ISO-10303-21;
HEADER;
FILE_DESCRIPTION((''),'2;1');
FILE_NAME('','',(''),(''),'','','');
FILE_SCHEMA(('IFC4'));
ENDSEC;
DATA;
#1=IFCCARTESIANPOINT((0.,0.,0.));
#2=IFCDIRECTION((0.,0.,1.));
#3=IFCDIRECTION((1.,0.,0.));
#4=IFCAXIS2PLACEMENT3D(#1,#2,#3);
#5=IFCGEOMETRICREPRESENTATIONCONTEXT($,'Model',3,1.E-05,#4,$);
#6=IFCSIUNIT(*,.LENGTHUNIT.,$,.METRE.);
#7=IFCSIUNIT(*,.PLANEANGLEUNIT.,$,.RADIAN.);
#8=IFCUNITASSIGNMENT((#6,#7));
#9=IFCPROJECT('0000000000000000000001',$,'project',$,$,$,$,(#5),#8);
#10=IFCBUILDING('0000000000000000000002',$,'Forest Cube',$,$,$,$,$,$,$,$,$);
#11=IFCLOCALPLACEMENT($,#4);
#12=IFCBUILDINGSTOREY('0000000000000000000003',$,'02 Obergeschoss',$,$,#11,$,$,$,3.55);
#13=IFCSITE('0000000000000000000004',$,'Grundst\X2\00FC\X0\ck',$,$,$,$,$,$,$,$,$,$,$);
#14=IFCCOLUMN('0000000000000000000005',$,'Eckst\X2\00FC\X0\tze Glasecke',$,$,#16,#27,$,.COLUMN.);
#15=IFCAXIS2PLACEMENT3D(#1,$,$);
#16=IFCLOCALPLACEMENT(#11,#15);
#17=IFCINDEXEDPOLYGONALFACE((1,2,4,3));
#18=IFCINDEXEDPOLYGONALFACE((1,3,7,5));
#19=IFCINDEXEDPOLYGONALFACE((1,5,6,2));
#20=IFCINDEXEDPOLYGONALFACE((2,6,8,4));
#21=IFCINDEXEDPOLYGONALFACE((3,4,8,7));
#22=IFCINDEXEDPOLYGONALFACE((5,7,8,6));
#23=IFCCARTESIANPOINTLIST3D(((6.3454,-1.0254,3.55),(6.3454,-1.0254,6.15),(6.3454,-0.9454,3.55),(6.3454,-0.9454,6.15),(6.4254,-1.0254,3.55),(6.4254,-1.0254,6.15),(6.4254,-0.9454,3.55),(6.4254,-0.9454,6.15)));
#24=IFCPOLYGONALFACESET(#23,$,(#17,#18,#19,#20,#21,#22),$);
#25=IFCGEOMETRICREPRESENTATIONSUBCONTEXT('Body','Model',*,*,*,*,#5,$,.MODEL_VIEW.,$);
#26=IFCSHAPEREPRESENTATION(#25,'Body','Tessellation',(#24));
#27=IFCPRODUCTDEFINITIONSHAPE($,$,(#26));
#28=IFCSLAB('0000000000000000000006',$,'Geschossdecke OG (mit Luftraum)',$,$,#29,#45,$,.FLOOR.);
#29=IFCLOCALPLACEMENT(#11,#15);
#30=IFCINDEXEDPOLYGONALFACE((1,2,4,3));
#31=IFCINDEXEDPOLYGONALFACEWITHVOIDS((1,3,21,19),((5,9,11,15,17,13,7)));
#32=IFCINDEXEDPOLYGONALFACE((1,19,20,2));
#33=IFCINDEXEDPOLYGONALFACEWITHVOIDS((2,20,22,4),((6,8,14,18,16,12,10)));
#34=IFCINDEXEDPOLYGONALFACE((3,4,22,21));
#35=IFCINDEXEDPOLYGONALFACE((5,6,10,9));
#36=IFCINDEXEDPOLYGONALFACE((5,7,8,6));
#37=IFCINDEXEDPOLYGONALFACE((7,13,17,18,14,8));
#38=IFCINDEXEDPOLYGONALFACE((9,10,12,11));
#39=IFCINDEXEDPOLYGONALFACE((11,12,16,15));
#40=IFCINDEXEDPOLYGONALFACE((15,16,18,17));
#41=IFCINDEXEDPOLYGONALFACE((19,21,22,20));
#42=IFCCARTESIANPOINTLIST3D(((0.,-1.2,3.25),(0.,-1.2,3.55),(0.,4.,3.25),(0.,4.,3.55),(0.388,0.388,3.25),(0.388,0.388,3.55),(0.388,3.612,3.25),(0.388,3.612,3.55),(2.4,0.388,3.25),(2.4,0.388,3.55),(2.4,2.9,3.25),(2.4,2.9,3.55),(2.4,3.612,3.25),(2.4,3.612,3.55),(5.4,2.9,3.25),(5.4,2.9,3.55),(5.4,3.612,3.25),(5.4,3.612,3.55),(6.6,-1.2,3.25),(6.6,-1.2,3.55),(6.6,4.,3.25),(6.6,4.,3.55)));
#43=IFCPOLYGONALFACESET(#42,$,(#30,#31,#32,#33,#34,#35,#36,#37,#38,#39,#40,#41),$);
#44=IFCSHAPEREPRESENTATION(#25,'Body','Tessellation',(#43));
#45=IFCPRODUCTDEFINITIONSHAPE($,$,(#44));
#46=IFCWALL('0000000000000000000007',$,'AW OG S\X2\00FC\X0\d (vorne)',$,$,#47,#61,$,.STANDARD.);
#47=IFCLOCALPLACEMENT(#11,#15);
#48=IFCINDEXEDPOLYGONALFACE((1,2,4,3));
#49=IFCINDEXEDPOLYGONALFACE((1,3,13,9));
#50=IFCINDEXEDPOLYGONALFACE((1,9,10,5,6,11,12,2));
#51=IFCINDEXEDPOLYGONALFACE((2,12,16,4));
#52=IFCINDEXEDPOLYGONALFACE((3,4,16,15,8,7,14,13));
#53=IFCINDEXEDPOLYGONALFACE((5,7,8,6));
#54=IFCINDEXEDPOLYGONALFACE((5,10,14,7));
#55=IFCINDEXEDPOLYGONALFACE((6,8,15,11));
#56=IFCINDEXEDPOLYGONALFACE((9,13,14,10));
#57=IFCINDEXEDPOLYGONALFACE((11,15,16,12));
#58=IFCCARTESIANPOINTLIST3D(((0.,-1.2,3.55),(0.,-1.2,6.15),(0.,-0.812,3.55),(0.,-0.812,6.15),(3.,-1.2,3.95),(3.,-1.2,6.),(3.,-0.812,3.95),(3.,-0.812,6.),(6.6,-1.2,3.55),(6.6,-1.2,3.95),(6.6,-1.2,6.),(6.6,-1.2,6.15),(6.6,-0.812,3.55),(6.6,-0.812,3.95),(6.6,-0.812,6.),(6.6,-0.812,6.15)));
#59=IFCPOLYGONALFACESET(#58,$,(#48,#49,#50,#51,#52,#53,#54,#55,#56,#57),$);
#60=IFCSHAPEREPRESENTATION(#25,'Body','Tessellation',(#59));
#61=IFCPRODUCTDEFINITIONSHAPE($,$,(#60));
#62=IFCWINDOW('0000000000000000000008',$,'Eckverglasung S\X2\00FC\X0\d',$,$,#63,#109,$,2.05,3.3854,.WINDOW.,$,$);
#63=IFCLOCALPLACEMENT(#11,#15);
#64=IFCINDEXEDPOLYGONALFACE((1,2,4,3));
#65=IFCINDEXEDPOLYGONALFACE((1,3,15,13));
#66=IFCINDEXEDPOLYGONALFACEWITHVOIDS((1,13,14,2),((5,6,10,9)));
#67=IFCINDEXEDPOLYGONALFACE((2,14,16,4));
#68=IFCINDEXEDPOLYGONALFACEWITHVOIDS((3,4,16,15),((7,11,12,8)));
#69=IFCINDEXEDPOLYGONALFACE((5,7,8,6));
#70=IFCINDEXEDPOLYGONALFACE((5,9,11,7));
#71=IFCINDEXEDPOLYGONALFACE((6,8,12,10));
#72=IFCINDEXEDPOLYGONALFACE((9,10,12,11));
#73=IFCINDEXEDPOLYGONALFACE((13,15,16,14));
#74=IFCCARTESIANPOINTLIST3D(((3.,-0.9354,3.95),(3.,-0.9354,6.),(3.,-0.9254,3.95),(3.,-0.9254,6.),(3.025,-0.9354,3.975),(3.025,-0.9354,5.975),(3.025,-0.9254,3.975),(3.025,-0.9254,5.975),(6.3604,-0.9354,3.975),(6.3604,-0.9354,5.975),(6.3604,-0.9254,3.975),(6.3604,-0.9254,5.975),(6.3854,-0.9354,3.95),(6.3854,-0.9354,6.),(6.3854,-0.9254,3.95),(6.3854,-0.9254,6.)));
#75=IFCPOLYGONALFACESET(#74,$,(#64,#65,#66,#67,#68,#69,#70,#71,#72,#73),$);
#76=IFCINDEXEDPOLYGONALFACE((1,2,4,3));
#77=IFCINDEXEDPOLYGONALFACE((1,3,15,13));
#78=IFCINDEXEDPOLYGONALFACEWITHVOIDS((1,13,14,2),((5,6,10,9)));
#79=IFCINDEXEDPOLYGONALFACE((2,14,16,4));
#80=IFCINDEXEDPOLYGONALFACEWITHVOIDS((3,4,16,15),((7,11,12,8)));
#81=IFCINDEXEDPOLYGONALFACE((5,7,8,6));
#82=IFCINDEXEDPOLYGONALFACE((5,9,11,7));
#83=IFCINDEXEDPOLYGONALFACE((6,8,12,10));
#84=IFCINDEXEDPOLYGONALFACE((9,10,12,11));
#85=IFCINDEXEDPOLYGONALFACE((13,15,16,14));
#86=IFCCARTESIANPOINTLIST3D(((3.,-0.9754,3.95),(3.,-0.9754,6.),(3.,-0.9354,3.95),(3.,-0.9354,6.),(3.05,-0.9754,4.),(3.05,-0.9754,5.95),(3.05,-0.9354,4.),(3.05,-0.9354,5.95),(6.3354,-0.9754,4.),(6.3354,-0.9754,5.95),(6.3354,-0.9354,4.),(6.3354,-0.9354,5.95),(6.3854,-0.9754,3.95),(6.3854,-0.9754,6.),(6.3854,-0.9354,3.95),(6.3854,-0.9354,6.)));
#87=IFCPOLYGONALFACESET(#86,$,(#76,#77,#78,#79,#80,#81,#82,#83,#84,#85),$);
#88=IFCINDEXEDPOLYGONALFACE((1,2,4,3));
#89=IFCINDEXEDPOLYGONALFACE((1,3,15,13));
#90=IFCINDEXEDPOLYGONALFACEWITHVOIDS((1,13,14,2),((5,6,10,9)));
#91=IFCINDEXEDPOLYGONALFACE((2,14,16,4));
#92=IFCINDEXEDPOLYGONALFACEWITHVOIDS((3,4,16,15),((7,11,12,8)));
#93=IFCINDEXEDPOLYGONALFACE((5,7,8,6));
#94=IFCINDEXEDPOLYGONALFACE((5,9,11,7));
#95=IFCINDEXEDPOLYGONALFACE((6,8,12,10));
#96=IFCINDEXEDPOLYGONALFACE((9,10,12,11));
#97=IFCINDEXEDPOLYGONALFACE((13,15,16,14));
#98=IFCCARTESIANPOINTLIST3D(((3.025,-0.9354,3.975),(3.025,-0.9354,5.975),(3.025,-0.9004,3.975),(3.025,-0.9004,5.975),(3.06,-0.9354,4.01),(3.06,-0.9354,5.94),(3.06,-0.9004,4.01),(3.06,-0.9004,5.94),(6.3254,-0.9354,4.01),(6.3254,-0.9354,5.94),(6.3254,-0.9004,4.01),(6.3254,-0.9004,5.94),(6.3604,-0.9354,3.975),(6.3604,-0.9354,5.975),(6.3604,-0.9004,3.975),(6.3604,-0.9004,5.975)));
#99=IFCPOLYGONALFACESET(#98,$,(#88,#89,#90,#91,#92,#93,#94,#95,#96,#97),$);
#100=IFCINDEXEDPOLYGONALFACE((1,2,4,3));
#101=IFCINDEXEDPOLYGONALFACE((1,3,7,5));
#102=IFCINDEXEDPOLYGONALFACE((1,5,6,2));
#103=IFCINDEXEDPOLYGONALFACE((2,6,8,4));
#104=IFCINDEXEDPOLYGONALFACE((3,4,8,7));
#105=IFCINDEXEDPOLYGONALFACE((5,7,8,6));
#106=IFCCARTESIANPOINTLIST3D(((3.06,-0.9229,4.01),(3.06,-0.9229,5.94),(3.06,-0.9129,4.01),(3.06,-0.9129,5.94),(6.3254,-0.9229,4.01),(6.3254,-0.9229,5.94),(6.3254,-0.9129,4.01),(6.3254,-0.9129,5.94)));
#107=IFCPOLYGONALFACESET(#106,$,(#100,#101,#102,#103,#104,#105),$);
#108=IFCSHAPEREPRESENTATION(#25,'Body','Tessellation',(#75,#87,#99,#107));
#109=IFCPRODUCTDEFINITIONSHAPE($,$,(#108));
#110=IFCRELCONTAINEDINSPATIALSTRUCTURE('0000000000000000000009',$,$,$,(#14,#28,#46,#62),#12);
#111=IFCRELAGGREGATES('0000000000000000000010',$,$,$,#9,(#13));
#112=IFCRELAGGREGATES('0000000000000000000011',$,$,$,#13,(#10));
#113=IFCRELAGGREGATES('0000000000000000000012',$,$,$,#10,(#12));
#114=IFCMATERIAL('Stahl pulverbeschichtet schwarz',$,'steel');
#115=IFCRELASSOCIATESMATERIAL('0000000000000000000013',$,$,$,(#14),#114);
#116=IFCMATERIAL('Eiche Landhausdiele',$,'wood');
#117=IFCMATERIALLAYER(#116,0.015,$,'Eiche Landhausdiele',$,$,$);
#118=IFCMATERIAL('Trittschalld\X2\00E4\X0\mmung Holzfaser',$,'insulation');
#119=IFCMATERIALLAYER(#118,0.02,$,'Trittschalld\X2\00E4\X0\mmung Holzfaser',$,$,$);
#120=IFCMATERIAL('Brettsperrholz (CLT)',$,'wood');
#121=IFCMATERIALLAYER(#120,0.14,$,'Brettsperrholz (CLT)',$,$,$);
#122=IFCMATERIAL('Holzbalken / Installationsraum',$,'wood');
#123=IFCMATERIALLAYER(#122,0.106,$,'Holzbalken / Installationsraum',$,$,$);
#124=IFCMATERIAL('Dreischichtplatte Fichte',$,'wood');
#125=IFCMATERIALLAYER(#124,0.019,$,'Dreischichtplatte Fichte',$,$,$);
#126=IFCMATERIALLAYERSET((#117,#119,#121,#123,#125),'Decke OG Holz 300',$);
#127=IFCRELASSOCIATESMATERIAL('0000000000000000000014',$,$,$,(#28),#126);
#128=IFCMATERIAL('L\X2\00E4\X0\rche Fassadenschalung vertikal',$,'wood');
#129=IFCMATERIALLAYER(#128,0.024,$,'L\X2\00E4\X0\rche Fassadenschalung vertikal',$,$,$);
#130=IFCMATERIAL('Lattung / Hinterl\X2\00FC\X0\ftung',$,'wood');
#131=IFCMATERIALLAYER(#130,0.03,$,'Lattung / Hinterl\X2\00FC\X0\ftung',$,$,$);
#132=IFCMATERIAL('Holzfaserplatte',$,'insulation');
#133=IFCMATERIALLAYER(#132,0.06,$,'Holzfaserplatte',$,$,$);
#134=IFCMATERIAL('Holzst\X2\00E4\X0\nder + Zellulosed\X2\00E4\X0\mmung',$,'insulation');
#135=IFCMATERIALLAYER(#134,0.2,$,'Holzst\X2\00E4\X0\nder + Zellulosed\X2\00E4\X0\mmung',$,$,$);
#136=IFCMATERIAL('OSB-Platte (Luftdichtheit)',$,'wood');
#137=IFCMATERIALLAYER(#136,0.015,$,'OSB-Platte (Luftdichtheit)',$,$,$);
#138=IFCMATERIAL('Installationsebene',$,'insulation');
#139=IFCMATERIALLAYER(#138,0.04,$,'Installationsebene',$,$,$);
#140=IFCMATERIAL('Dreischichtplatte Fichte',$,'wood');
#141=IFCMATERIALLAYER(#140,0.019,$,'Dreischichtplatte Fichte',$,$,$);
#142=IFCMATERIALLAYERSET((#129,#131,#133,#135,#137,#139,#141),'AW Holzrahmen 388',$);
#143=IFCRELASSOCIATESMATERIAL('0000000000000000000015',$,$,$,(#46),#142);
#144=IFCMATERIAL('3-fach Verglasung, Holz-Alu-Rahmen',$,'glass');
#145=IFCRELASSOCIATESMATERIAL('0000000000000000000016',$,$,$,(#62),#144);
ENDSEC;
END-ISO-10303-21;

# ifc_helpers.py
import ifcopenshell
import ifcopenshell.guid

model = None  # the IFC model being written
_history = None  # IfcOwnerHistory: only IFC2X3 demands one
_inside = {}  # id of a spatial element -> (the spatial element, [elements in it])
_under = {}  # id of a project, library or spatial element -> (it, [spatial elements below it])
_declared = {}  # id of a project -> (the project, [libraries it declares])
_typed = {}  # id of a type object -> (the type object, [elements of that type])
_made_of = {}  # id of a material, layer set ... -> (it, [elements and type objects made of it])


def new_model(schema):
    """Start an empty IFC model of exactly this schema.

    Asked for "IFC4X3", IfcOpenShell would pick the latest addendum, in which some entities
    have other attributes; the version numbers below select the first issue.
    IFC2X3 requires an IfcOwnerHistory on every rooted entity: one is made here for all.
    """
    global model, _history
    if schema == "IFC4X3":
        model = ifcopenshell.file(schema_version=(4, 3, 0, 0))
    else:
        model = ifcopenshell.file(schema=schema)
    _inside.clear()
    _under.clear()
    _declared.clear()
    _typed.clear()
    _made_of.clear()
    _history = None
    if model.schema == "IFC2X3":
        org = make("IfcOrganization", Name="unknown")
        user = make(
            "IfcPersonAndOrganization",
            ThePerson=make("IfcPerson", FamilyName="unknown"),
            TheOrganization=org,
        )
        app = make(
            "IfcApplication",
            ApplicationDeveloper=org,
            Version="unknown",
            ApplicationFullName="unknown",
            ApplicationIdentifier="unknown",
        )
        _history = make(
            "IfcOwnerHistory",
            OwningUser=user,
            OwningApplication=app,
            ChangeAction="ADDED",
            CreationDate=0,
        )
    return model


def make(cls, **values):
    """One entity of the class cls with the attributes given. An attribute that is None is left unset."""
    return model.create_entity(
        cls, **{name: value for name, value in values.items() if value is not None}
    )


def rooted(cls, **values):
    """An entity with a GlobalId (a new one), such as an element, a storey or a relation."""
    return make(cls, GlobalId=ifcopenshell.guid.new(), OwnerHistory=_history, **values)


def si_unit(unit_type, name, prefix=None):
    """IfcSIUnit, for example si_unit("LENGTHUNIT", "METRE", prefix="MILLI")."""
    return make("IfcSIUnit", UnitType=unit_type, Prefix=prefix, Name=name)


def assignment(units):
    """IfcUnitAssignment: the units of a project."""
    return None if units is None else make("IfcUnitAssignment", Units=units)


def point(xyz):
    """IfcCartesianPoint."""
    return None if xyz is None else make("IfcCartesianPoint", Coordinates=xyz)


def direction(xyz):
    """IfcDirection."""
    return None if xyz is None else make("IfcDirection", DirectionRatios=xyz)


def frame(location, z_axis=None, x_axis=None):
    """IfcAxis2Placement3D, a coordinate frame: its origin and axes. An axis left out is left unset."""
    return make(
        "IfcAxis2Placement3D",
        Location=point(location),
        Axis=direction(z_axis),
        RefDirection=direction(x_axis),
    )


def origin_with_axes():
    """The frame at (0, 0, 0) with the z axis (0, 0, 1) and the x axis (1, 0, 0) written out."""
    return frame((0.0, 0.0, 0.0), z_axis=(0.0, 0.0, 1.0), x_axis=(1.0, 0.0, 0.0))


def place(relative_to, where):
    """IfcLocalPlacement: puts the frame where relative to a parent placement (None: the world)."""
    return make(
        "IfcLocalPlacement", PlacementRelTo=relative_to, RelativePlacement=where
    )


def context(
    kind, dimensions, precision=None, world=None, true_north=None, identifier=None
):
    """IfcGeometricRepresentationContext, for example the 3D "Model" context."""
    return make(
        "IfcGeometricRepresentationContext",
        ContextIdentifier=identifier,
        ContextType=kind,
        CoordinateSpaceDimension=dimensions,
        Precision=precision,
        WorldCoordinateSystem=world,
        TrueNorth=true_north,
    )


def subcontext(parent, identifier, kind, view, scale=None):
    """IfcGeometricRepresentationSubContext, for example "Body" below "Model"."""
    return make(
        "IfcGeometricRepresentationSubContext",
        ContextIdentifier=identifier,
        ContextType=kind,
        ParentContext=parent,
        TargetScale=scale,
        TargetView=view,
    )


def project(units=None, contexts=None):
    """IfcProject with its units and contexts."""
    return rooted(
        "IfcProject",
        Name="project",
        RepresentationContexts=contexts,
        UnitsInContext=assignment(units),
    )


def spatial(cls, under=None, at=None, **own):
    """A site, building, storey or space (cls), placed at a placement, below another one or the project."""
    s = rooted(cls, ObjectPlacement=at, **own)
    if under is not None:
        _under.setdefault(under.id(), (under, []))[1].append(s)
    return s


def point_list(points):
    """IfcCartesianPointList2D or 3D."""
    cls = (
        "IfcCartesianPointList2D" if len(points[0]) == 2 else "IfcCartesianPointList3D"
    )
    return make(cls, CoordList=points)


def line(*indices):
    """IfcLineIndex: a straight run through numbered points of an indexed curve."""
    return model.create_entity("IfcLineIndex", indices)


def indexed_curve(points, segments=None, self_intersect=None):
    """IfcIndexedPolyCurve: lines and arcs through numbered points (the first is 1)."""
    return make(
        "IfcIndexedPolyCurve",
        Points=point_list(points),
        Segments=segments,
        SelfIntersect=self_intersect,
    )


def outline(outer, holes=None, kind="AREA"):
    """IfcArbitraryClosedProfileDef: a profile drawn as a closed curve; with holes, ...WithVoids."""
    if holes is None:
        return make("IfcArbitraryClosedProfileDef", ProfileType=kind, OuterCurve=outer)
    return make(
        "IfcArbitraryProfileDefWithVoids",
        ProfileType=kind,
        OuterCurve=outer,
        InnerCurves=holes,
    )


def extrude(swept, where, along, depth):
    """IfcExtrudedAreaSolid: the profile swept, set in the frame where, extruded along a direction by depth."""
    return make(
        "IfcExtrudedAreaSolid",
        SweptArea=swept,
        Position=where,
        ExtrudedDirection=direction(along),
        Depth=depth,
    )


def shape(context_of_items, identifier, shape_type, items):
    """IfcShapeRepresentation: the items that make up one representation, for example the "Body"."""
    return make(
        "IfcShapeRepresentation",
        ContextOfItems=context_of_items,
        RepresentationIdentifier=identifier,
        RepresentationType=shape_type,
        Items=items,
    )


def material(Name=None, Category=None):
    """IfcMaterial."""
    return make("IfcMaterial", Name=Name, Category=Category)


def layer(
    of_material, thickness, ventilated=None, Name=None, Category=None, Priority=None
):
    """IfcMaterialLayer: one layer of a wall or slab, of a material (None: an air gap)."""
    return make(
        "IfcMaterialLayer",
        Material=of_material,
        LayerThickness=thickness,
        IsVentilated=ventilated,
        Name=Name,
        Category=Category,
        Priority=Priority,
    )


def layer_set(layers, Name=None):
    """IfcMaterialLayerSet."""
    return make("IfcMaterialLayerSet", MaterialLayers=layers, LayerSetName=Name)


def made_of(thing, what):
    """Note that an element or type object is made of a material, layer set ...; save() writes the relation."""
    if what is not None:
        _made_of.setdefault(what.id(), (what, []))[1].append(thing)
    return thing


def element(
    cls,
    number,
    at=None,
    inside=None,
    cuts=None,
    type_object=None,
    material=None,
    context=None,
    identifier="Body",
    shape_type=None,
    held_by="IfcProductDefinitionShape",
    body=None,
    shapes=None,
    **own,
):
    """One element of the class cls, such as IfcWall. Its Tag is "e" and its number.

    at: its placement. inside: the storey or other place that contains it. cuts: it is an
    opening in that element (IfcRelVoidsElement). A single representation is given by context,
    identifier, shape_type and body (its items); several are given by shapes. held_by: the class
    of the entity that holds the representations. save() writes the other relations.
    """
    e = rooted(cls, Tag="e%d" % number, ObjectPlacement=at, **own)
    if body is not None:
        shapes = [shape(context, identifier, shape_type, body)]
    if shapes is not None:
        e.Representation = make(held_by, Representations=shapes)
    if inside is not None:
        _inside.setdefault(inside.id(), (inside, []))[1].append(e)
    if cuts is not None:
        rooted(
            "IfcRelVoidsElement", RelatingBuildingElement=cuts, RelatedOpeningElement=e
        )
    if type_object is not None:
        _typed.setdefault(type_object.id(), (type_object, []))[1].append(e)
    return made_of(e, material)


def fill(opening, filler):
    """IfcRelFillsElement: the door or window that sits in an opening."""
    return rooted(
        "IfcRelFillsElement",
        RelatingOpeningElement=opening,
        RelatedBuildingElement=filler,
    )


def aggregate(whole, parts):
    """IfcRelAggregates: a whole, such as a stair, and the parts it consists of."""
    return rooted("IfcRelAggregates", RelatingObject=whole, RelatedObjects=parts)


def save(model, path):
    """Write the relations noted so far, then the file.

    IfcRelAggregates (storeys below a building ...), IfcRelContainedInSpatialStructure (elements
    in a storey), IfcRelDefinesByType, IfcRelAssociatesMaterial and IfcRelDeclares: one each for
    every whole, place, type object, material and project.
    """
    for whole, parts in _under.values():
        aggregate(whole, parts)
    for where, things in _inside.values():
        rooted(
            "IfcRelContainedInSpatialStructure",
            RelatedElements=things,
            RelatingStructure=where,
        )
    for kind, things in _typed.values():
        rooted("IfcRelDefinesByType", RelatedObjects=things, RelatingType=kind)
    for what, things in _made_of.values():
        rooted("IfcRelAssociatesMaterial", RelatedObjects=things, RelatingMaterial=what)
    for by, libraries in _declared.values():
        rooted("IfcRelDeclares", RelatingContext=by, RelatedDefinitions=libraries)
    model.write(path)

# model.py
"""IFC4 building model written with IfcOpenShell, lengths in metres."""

from ifc_helpers import new_model, si_unit, frame, origin_with_axes, place, context, subcontext, project, spatial, line, indexed_curve, outline, extrude, material, layer, layer_set, element, fill, save


model = new_model("IFC4")

# Units and contexts
model_context = context("Model", 3, precision=1e-05, world=origin_with_axes())
body_context = subcontext(model_context, "Body", "Model", "MODEL_VIEW")
ifc_project = project(units=[si_unit("LENGTHUNIT", "METRE"), si_unit("PLANEANGLEUNIT", "RADIAN")], contexts=[model_context])

# Site, building, storey
site = spatial("IfcSite", under=ifc_project, Name="Grundstück")
building = spatial("IfcBuilding", under=site, Name="Forest Cube")
storey_placement = place(None, origin_with_axes())
storey = spatial("IfcBuildingStorey", under=building, at=storey_placement, Name="02 Obergeschoss", Elevation=3.55)

# Column
ifc_material_1 = material(Name="Stahl pulverbeschichtet schwarz", Category="steel")
column_placement = place(storey_placement, frame((6.3854, -0.9854, 3.55), z_axis=(0.0, 0.0, 1.0), x_axis=(1.0, 0.0, 0.0)))
element("IfcColumn", 1, at=column_placement, inside=storey, material=ifc_material_1, Name="Eckstütze Glasecke", PredefinedType="COLUMN", context=body_context, shape_type="SweptSolid", body=[
    extrude(outline(indexed_curve([(-0.04, -0.04), (0.04, -0.04), (0.04, 0.04), (-0.04, 0.04)])), None, (0.0, 0.0, 1.0), 2.6),
])

# Slab, openings
ifc_material_2 = material(Name="Eiche Landhausdiele", Category="wood")
ifc_layer_1 = layer(ifc_material_2, 0.015, Name="Eiche Landhausdiele")
ifc_material_3 = material(Name="Trittschalldämmung Holzfaser", Category="insulation")
ifc_layer_2 = layer(ifc_material_3, 0.02, Name="Trittschalldämmung Holzfaser")
ifc_material_4 = material(Name="Brettsperrholz (CLT)", Category="wood")
ifc_layer_3 = layer(ifc_material_4, 0.14, Name="Brettsperrholz (CLT)")
ifc_material_5 = material(Name="Holzbalken / Installationsraum", Category="wood")
ifc_layer_4 = layer(ifc_material_5, 0.106, Name="Holzbalken / Installationsraum")
ifc_material_6 = material(Name="Dreischichtplatte Fichte", Category="wood")
ifc_layer_5 = layer(ifc_material_6, 0.019, Name="Dreischichtplatte Fichte")
ifc_layer_set_1 = layer_set([ifc_layer_1, ifc_layer_2, ifc_layer_3, ifc_layer_4, ifc_layer_5], Name="Decke OG Holz 300")
slab_placement = place(storey_placement, frame((0.0, 0.0, 3.25), z_axis=(0.0, 0.0, 1.0), x_axis=(1.0, 0.0, 0.0)))
slab = element("IfcSlab", 2, at=slab_placement, inside=storey, material=ifc_layer_set_1, Name="Geschossdecke OG (mit Luftraum)", PredefinedType="FLOOR", context=body_context, shape_type="SweptSolid", body=[
    extrude(outline(indexed_curve([(0.0, -1.2), (6.6, -1.2), (6.6, 4.0), (0.0, 4.0)])), None, (0.0, 0.0, 1.0), 0.3),
])
opening_1_placement = place(slab_placement, frame((0.0, 0.0, -0.1), z_axis=(0.0, 0.0, 1.0), x_axis=(1.0, 0.0, 0.0)))
element("IfcOpeningElement", 3, at=opening_1_placement, cuts=slab, context=body_context, shape_type="SweptSolid", body=[
    extrude(outline(indexed_curve([(0.388, 0.388), (2.4, 0.388), (2.4, 3.612), (0.388, 3.612)])), None, (0.0, 0.0, 1.0), 0.5),
])
opening_2_placement = place(slab_placement, frame((0.0, 0.0, -0.1), z_axis=(0.0, 0.0, 1.0), x_axis=(1.0, 0.0, 0.0)))
element("IfcOpeningElement", 4, at=opening_2_placement, cuts=slab, context=body_context, shape_type="SweptSolid", body=[
    extrude(outline(indexed_curve([(2.4, 2.9), (5.4, 2.9), (5.4, 3.612), (2.4, 3.612)])), None, (0.0, 0.0, 1.0), 0.5),
])

# Wall, opening, window
ifc_material_7 = material(Name="Lärche Fassadenschalung vertikal", Category="wood")
ifc_layer_6 = layer(ifc_material_7, 0.024, Name="Lärche Fassadenschalung vertikal")
ifc_material_8 = material(Name="Lattung / Hinterlüftung", Category="wood")
ifc_layer_7 = layer(ifc_material_8, 0.03, Name="Lattung / Hinterlüftung")
ifc_material_9 = material(Name="Holzfaserplatte", Category="insulation")
ifc_layer_8 = layer(ifc_material_9, 0.06, Name="Holzfaserplatte")
ifc_material_10 = material(Name="Holzständer + Zellulosedämmung", Category="insulation")
ifc_layer_9 = layer(ifc_material_10, 0.2, Name="Holzständer + Zellulosedämmung")
ifc_material_11 = material(Name="OSB-Platte (Luftdichtheit)", Category="wood")
ifc_layer_10 = layer(ifc_material_11, 0.015, Name="OSB-Platte (Luftdichtheit)")
ifc_material_12 = material(Name="Installationsebene", Category="insulation")
ifc_layer_11 = layer(ifc_material_12, 0.04, Name="Installationsebene")
ifc_material_13 = material(Name="Dreischichtplatte Fichte", Category="wood")
ifc_layer_12 = layer(ifc_material_13, 0.019, Name="Dreischichtplatte Fichte")
ifc_layer_set_2 = layer_set([ifc_layer_6, ifc_layer_7, ifc_layer_8, ifc_layer_9, ifc_layer_10, ifc_layer_11, ifc_layer_12], Name="AW Holzrahmen 388")
wall_1_placement = place(storey_placement, frame((0.0, -1.2, 3.55), z_axis=(0.0, 0.0, 1.0), x_axis=(1.0, 0.0, 0.0)))
wall_1 = element("IfcWall", 5, at=wall_1_placement, inside=storey, material=ifc_layer_set_2, Name="AW OG Süd (vorne)", PredefinedType="STANDARD", context=body_context, shape_type="SweptSolid", body=[
    extrude(outline(indexed_curve([(0.0, 0.0), (0.0, 0.388), (6.6, 0.388), (6.6, 0.0), (0.0, 0.0)], self_intersect=False)), origin_with_axes(), (0.0, 0.0, 1.0), 2.6),
])
opening_3_placement = place(wall_1_placement, frame((3.0, -0.1, 0.4), z_axis=(0.0, 0.0, 1.0), x_axis=(1.0, 0.0, 0.0)))
opening_3 = element("IfcOpeningElement", 6, at=opening_3_placement, cuts=wall_1, context=body_context, shape_type="SweptSolid", body=[
    extrude(outline(indexed_curve([(0.0, 0.0), (0.0, 0.588), (3.6, 0.588), (3.6, 0.0), (0.0, 0.0)], self_intersect=False)), origin_with_axes(), (0.0, 0.0, 1.0), 2.05),
])
ifc_material_14 = material(Name="3-fach Verglasung, Holz-Alu-Rahmen", Category="glass")
window_1_placement = place(storey_placement, frame((3.0, -1.0254, 3.95), z_axis=(0.0, 0.0, 1.0), x_axis=(1.0, 0.0, 0.0)))
window_1 = element("IfcWindow", 7, at=window_1_placement, inside=storey, material=ifc_material_14, Name="Eckverglasung Süd", OverallHeight=2.05, OverallWidth=3.3854, PredefinedType="WINDOW", context=body_context, shape_type="SweptSolid", body=[
    extrude(outline(indexed_curve([(0.0, 0.0), (3.3854, 0.0), (3.3854, 2.05), (0.0, 2.05)], segments=[line(1, 2, 3, 4, 1)]), holes=[indexed_curve([(0.025, 0.025), (3.3604, 0.025), (3.3604, 2.025), (0.025, 2.025)], segments=[line(1, 2, 3, 4, 1)])]), frame((0.0, 0.09, 0.0), z_axis=(0.0, -1.0, 0.0), x_axis=(1.0, 0.0, 0.0)), (0.0, 0.0, -1.0), 0.01),
    extrude(outline(indexed_curve([(0.0, 0.0), (3.3854, 0.0), (3.3854, 2.05), (0.0, 2.05)], segments=[line(1, 2, 3, 4, 1)]), holes=[indexed_curve([(0.05, 0.05), (3.3354, 0.05), (3.3354, 2.0), (0.05, 2.0)], segments=[line(1, 2, 3, 4, 1)])]), frame((0.0, 0.05, 0.0), z_axis=(0.0, -1.0, 0.0), x_axis=(1.0, 0.0, 0.0)), (0.0, 0.0, -1.0), 0.04),
    extrude(outline(indexed_curve([(0.0, 0.0), (3.3354, 0.0), (3.3354, 2.0), (0.0, 2.0)], segments=[line(1, 2, 3, 4, 1)]), holes=[indexed_curve([(0.035, 0.035), (3.3004, 0.035), (3.3004, 1.965), (0.035, 1.965)], segments=[line(1, 2, 3, 4, 1)])]), frame((0.025, 0.09, 0.025), z_axis=(0.0, -1.0, 0.0), x_axis=(1.0, 0.0, 0.0)), (0.0, 0.0, -1.0), 0.035),
    extrude(outline(indexed_curve([(0.035, 0.035), (3.3004, 0.035), (3.3004, 1.965), (0.035, 1.965)], segments=[line(1, 2, 3, 4, 1)])), frame((0.025, 0.1025, 0.025), z_axis=(0.0, -1.0, 0.0), x_axis=(1.0, 0.0, 0.0)), (0.0, 0.0, -1.0), 0.01),
])
fill(opening_3, window_1)

save(model, "model.ifc")
